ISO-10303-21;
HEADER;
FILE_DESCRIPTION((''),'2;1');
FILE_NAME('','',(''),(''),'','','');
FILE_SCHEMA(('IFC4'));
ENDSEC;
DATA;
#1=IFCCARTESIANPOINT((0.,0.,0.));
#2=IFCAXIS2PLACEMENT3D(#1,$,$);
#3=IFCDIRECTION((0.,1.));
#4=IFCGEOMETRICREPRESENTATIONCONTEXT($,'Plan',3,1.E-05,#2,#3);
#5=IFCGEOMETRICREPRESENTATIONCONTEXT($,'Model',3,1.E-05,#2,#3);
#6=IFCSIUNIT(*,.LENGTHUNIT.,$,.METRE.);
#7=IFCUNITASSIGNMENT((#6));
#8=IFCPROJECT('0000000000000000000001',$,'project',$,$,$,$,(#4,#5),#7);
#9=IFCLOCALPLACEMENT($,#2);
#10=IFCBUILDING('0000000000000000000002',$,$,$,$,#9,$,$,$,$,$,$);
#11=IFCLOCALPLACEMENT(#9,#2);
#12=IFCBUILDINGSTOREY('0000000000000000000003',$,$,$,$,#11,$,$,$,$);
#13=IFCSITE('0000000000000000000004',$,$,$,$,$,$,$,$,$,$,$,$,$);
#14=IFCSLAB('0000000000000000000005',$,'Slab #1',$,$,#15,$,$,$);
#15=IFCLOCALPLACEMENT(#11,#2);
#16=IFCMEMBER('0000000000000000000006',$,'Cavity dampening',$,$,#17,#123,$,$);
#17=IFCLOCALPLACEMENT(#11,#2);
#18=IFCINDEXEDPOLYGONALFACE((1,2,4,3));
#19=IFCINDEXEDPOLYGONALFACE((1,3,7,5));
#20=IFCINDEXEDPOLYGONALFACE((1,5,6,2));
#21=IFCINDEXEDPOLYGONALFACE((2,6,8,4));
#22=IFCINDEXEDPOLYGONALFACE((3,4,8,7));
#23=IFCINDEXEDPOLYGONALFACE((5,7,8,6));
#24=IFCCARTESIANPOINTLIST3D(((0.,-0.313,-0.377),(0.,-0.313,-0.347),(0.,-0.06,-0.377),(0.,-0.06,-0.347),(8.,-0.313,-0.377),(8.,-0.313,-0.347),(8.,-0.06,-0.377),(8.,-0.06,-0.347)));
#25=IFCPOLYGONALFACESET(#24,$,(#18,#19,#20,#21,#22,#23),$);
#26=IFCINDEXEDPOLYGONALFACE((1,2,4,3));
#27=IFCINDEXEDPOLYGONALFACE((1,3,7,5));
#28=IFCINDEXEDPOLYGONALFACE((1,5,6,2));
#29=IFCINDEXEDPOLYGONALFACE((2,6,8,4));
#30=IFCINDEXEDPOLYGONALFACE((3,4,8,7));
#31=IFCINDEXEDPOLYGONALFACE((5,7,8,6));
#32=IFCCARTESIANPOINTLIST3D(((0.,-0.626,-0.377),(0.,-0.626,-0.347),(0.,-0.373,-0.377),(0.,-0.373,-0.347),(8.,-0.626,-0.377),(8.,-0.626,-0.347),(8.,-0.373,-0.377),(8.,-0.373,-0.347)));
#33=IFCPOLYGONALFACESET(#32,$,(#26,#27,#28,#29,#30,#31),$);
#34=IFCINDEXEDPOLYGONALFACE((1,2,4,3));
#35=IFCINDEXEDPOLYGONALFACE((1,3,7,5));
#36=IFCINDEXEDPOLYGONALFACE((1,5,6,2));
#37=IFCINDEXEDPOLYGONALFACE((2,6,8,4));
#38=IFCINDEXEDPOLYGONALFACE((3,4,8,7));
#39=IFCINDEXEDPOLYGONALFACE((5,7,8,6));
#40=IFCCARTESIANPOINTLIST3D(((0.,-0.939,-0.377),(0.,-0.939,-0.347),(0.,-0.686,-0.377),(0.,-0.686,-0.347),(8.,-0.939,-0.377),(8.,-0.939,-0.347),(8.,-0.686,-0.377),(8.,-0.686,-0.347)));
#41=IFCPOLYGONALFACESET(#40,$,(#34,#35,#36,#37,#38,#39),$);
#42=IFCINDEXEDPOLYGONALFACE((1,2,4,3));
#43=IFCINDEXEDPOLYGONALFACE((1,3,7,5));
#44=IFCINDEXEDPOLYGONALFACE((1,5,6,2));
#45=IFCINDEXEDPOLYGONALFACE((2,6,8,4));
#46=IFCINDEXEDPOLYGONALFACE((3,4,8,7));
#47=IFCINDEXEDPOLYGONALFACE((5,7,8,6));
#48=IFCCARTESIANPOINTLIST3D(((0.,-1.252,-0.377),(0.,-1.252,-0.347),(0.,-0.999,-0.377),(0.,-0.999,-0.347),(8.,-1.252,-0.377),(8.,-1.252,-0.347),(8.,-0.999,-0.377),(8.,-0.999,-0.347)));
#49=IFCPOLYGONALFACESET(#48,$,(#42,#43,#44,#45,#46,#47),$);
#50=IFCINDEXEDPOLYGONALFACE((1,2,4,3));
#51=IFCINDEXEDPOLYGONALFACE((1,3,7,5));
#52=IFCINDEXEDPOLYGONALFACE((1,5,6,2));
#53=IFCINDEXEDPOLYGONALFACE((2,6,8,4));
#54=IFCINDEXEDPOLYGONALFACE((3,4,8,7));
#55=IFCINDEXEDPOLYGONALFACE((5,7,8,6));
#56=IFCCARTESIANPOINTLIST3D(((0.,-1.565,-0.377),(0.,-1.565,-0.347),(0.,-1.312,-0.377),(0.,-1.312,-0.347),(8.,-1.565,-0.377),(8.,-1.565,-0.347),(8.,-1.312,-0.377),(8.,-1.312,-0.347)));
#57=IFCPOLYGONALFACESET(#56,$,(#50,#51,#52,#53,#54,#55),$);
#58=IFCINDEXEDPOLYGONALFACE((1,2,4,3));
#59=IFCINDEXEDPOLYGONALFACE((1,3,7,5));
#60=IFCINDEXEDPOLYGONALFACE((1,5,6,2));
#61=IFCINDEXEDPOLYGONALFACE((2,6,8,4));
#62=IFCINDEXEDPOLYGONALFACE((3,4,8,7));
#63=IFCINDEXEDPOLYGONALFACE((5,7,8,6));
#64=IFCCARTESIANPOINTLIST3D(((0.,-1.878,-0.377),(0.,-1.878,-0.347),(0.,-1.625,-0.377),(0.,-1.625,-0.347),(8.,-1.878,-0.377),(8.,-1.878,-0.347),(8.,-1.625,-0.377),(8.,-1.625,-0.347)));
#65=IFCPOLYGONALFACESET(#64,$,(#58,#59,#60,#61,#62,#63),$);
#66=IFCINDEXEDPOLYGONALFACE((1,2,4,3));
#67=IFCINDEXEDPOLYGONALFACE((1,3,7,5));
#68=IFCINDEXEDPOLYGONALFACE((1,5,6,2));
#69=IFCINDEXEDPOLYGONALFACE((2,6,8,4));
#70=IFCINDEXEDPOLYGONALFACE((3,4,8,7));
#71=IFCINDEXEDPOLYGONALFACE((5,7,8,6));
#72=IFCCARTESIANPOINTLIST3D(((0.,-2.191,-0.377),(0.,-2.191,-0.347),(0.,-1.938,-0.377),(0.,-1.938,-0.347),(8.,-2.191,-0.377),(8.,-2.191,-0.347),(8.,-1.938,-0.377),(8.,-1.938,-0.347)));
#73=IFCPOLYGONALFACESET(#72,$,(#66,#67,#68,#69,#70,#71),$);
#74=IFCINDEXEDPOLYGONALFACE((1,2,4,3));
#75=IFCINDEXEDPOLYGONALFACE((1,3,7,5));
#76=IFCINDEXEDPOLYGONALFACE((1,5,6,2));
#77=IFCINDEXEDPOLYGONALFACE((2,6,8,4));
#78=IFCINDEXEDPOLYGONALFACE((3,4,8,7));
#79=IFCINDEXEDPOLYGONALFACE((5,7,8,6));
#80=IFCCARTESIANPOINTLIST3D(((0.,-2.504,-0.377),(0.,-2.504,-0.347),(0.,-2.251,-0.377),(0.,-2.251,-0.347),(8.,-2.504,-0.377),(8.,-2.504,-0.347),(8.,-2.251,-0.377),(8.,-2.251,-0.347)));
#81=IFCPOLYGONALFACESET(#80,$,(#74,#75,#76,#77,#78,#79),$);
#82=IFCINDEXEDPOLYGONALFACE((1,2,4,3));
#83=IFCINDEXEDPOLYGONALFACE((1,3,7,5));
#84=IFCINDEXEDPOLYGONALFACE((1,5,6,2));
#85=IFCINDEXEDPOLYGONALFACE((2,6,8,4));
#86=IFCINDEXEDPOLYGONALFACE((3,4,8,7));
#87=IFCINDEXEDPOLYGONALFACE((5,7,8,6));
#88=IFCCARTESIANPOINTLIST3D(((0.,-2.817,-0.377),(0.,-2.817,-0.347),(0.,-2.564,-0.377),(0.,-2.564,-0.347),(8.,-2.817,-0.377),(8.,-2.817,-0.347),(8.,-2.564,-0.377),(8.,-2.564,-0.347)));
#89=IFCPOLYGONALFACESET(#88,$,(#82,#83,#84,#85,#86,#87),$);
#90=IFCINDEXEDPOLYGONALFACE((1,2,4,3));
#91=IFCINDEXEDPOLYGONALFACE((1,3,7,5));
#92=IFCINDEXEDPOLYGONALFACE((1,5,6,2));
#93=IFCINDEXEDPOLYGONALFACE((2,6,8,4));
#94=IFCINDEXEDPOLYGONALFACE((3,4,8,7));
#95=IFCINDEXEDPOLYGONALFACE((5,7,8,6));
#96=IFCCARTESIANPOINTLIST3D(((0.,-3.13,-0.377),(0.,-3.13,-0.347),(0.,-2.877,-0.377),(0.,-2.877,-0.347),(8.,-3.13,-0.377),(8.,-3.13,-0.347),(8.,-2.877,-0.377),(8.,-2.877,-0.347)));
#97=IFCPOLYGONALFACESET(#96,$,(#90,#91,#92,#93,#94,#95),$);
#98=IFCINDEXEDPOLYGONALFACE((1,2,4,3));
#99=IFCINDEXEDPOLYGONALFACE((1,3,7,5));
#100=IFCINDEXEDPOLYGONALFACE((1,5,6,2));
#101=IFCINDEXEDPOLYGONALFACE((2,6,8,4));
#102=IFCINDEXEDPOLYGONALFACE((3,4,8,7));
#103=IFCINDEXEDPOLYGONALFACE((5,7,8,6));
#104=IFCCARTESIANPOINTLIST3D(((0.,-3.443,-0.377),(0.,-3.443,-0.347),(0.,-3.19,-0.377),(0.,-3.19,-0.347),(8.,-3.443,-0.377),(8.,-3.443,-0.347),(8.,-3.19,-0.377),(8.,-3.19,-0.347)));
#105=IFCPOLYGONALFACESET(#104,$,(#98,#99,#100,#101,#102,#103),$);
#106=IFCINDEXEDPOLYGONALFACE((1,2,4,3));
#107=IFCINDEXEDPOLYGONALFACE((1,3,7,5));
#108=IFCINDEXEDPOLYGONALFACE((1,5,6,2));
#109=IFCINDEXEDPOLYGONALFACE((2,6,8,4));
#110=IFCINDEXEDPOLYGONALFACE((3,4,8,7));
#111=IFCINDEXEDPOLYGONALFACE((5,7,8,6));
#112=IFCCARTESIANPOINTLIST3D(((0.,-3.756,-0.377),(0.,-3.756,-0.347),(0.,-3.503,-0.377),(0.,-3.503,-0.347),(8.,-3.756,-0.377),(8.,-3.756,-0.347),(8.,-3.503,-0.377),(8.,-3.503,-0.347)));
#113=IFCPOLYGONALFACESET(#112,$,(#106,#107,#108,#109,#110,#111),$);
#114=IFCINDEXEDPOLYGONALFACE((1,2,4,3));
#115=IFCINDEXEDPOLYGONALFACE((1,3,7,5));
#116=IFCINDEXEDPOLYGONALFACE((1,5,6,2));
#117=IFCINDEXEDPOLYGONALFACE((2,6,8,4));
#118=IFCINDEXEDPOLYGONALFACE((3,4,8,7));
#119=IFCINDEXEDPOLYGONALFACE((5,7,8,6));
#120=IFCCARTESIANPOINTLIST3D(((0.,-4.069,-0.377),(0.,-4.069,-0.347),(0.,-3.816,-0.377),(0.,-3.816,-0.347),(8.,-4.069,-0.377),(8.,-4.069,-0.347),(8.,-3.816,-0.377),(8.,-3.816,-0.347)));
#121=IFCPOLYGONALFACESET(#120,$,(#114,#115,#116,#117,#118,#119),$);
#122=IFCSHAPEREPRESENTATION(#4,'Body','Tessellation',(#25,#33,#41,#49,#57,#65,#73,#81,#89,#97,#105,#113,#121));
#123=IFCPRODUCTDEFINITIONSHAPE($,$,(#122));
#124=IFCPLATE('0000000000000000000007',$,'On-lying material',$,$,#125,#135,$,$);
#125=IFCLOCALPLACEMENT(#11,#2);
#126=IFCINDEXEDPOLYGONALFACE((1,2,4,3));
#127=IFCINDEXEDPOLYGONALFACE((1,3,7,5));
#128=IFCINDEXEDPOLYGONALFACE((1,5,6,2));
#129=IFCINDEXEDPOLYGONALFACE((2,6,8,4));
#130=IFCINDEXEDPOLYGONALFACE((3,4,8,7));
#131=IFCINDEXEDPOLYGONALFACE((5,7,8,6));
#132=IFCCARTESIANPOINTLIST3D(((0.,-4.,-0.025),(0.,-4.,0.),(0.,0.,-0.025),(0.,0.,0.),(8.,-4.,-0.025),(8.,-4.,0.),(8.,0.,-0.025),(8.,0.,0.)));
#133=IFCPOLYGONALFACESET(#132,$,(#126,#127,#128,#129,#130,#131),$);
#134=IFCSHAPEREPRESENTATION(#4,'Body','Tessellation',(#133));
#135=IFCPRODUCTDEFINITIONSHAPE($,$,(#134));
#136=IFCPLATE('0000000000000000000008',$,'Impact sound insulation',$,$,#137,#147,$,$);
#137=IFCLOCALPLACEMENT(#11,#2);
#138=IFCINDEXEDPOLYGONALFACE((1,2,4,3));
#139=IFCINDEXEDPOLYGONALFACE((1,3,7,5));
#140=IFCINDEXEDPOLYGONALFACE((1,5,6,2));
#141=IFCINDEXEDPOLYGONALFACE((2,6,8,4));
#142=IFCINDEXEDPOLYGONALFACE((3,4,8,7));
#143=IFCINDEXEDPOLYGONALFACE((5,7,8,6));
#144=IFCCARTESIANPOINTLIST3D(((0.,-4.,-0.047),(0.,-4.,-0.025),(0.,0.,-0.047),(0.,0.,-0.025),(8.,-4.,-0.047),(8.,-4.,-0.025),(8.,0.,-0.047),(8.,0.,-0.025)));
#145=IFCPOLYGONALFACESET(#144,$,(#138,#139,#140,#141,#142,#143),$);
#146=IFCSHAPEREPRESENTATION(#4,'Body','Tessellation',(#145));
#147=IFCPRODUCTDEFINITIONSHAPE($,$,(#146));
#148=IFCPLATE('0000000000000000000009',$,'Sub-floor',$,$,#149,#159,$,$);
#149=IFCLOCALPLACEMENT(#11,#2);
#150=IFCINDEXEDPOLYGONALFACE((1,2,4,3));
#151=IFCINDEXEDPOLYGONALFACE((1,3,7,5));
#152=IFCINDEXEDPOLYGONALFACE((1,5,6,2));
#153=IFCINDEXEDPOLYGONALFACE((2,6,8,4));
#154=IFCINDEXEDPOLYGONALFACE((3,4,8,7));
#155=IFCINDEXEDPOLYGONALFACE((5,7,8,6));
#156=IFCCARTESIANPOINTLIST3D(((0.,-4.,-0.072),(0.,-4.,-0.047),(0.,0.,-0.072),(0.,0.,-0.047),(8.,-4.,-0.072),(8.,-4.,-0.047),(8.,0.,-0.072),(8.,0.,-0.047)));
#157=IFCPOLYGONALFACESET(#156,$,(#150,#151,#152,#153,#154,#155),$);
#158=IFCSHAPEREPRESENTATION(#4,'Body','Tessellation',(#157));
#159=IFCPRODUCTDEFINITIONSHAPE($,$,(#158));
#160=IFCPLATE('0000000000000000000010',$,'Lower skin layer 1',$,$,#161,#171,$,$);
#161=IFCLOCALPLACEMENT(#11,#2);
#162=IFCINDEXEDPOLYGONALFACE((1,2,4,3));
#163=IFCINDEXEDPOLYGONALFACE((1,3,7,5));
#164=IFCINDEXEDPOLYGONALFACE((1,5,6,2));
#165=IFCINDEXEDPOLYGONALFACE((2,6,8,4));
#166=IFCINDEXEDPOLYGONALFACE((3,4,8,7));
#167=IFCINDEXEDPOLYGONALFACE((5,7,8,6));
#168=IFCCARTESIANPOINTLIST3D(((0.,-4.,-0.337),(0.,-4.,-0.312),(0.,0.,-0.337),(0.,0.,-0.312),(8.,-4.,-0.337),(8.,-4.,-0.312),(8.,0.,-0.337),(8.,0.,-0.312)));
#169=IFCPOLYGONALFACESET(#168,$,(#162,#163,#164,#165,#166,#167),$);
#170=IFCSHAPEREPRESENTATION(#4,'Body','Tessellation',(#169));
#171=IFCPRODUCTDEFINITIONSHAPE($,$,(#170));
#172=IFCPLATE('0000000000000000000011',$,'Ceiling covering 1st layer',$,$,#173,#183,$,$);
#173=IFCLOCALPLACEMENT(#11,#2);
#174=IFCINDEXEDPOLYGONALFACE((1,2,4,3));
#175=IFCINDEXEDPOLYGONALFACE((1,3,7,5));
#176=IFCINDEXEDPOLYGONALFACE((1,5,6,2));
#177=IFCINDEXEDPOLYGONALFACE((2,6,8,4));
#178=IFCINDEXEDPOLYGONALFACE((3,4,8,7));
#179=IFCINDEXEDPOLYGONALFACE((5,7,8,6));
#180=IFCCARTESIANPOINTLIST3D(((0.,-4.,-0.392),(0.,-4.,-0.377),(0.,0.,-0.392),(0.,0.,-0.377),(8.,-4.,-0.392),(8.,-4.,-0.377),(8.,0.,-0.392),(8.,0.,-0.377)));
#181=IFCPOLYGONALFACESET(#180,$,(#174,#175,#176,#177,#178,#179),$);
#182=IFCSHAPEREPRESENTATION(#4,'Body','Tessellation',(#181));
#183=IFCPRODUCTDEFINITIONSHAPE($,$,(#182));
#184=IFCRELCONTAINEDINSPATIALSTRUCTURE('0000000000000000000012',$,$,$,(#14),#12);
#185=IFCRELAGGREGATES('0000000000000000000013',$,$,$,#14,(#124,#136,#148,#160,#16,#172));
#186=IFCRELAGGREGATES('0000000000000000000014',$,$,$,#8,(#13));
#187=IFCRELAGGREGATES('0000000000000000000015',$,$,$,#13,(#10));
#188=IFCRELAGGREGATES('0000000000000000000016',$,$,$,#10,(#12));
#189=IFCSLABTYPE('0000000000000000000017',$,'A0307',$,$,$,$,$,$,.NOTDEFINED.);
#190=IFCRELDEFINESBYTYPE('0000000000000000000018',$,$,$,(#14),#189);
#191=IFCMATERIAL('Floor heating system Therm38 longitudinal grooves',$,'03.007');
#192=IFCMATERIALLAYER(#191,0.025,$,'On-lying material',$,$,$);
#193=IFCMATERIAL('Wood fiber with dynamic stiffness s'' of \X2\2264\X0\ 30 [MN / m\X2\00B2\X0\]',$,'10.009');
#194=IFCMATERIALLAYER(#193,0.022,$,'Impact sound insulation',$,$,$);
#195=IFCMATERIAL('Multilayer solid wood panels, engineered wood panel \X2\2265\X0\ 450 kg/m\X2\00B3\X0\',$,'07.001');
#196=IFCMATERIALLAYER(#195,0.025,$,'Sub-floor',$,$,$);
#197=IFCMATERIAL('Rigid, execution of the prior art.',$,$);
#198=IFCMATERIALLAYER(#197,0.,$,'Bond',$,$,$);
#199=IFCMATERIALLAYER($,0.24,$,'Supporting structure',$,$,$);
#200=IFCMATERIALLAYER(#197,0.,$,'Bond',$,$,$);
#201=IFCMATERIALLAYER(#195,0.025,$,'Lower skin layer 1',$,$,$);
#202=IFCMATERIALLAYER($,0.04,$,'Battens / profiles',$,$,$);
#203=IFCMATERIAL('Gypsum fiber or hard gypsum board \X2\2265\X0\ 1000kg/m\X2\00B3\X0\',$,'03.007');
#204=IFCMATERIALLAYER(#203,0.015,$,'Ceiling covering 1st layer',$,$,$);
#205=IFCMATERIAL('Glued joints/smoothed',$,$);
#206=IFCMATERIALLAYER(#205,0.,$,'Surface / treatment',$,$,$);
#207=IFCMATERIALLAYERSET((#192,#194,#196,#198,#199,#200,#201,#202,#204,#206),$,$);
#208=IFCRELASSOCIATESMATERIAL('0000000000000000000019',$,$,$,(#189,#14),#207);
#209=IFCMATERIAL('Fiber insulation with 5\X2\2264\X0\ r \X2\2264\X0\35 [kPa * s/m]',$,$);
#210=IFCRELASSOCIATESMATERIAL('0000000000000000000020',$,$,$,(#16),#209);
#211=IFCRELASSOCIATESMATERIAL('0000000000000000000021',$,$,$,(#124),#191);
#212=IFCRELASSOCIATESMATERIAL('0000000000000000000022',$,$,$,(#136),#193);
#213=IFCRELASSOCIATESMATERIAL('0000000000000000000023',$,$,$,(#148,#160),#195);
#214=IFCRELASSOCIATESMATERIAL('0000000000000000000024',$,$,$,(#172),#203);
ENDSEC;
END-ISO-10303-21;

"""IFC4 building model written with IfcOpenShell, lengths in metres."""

from ifc_helpers import new_model, si_unit, direction, frame, frame_2d, origin, origin_with_axes, place, context, project, spatial, rectangle, extrude, material, layer, layer_set, type_object, element, aggregate, save


model = new_model("IFC4")

# Units and contexts
plan_context = context("Plan", 3, precision=1e-05, world=origin(), true_north=direction((0.0, 1.0)))
model_context = context("Model", 3, precision=1e-05, world=origin(), true_north=direction((0.0, 1.0)))
ifc_project = project(units=[si_unit("LENGTHUNIT", "METRE")], contexts=[plan_context, model_context])

# Site, building, storey
site = spatial("IfcSite", under=ifc_project)
building_placement = place(None, origin())
building = spatial("IfcBuilding", under=site, at=building_placement)
storey_placement = place(building_placement, origin())
storey = spatial("IfcBuildingStorey", under=building, at=storey_placement)

# Slab, member, plates
ifc_material_1 = material(Name="Floor heating system Therm38 longitudinal grooves", Category="03.007")
ifc_layer_1 = layer(ifc_material_1, 0.025, Name="On-lying material")
ifc_material_2 = material(Name="Wood fiber with dynamic stiffness s' of ≤ 30 [MN / m²]", Category="10.009")
ifc_layer_2 = layer(ifc_material_2, 0.022, Name="Impact sound insulation")
ifc_material_3 = material(Name="Multilayer solid wood panels, engineered wood panel ≥ 450 kg/m³", Category="07.001")
ifc_layer_3 = layer(ifc_material_3, 0.025, Name="Sub-floor")
ifc_material_4 = material(Name="Rigid, execution of the prior art.")
ifc_layer_4 = layer(ifc_material_4, 0.0, Name="Bond")
ifc_layer_5 = layer(None, 0.24, Name="Supporting structure")
ifc_layer_6 = layer(ifc_material_4, 0.0, Name="Bond")
ifc_layer_7 = layer(ifc_material_3, 0.025, Name="Lower skin layer 1")
ifc_layer_8 = layer(None, 0.04, Name="Battens / profiles")
ifc_material_5 = material(Name="Gypsum fiber or hard gypsum board ≥ 1000kg/m³", Category="03.007")
ifc_layer_9 = layer(ifc_material_5, 0.015, Name="Ceiling covering 1st layer")
ifc_material_6 = material(Name="Glued joints/smoothed")
ifc_layer_10 = layer(ifc_material_6, 0.0, Name="Surface / treatment")
ifc_layer_set = layer_set([ifc_layer_1, ifc_layer_2, ifc_layer_3, ifc_layer_4, ifc_layer_5, ifc_layer_6, ifc_layer_7, ifc_layer_8, ifc_layer_9, ifc_layer_10])
slab_type = type_object("IfcSlabType", Name="A0307", PredefinedType="NOTDEFINED", material=ifc_layer_set)
slab_placement = place(None, frame((0.0, 0.0, 0.0), z_axis=(0.0, 0.0, -1.0), x_axis=(1.0, 0.0, 0.0)))
slab = element("IfcSlab", 1, at=slab_placement, inside=storey, type_object=slab_type, material=ifc_layer_set, Name="Slab #1")
ifc_material_7 = material(Name="Fiber insulation with 5≤ r ≤35 [kPa * s/m]")
member_1_placement = place(slab_placement, origin())
member_1 = element("IfcMember", 2, at=member_1_placement, material=ifc_material_7, Name="Cavity dampening", context=plan_context, shape_type="SweptSolid", body=[
    extrude(rectangle(XDim=0.253, YDim=0.03, at=frame_2d((0.1265, 0.015), x_axis=(1.0, 0.0))), frame((0.0, 0.06, 0.347), z_axis=(1.0, 0.0, 0.0), x_axis=(0.0, 1.0, 0.0)), (0.0, 0.0, 1.0), 8.0),
    extrude(rectangle(XDim=0.253, YDim=0.03, at=frame_2d((0.1265, 0.015), x_axis=(1.0, 0.0))), frame((0.0, 0.373, 0.347), z_axis=(1.0, 0.0, 0.0), x_axis=(0.0, 1.0, 0.0)), (0.0, 0.0, 1.0), 8.0),
    extrude(rectangle(XDim=0.253, YDim=0.03, at=frame_2d((0.1265, 0.015), x_axis=(1.0, 0.0))), frame((0.0, 0.686, 0.347), z_axis=(1.0, 0.0, 0.0), x_axis=(0.0, 1.0, 0.0)), (0.0, 0.0, 1.0), 8.0),
    extrude(rectangle(XDim=0.253, YDim=0.03, at=frame_2d((0.1265, 0.015), x_axis=(1.0, 0.0))), frame((0.0, 0.999, 0.347), z_axis=(1.0, 0.0, 0.0), x_axis=(0.0, 1.0, 0.0)), (0.0, 0.0, 1.0), 8.0),
    extrude(rectangle(XDim=0.253, YDim=0.03, at=frame_2d((0.1265, 0.015), x_axis=(1.0, 0.0))), frame((0.0, 1.312, 0.347), z_axis=(1.0, 0.0, 0.0), x_axis=(0.0, 1.0, 0.0)), (0.0, 0.0, 1.0), 8.0),
    extrude(rectangle(XDim=0.253, YDim=0.03, at=frame_2d((0.1265, 0.015), x_axis=(1.0, 0.0))), frame((0.0, 1.625, 0.347), z_axis=(1.0, 0.0, 0.0), x_axis=(0.0, 1.0, 0.0)), (0.0, 0.0, 1.0), 8.0),
    extrude(rectangle(XDim=0.253, YDim=0.03, at=frame_2d((0.1265, 0.015), x_axis=(1.0, 0.0))), frame((0.0, 1.938, 0.347), z_axis=(1.0, 0.0, 0.0), x_axis=(0.0, 1.0, 0.0)), (0.0, 0.0, 1.0), 8.0),
    extrude(rectangle(XDim=0.253, YDim=0.03, at=frame_2d((0.1265, 0.015), x_axis=(1.0, 0.0))), frame((0.0, 2.251, 0.347), z_axis=(1.0, 0.0, 0.0), x_axis=(0.0, 1.0, 0.0)), (0.0, 0.0, 1.0), 8.0),
    extrude(rectangle(XDim=0.253, YDim=0.03, at=frame_2d((0.1265, 0.015), x_axis=(1.0, 0.0))), frame((0.0, 2.564, 0.347), z_axis=(1.0, 0.0, 0.0), x_axis=(0.0, 1.0, 0.0)), (0.0, 0.0, 1.0), 8.0),
    extrude(rectangle(XDim=0.253, YDim=0.03, at=frame_2d((0.1265, 0.015), x_axis=(1.0, 0.0))), frame((0.0, 2.877, 0.347), z_axis=(1.0, 0.0, 0.0), x_axis=(0.0, 1.0, 0.0)), (0.0, 0.0, 1.0), 8.0),
    extrude(rectangle(XDim=0.253, YDim=0.03, at=frame_2d((0.1265, 0.015), x_axis=(1.0, 0.0))), frame((0.0, 3.19, 0.347), z_axis=(1.0, 0.0, 0.0), x_axis=(0.0, 1.0, 0.0)), (0.0, 0.0, 1.0), 8.0),
    extrude(rectangle(XDim=0.253, YDim=0.03, at=frame_2d((0.1265, 0.015), x_axis=(1.0, 0.0))), frame((0.0, 3.503, 0.347), z_axis=(1.0, 0.0, 0.0), x_axis=(0.0, 1.0, 0.0)), (0.0, 0.0, 1.0), 8.0),
    extrude(rectangle(XDim=0.253, YDim=0.03, at=frame_2d((0.1265, 0.015), x_axis=(1.0, 0.0))), frame((0.0, 3.816, 0.347), z_axis=(1.0, 0.0, 0.0), x_axis=(0.0, 1.0, 0.0)), (0.0, 0.0, 1.0), 8.0),
])
plate_1_placement = place(slab_placement, origin())
plate_1 = element("IfcPlate", 3, at=plate_1_placement, material=ifc_material_1, Name="On-lying material", context=plan_context, shape_type="SweptSolid", body=[
    extrude(rectangle(XDim=8.0, YDim=4.0, at=frame_2d((4.0, 2.0), x_axis=(1.0, 0.0))), origin_with_axes(), (0.0, 0.0, 1.0), 0.025),
])
plate_2_placement = place(slab_placement, origin())
plate_2 = element("IfcPlate", 4, at=plate_2_placement, material=ifc_material_2, Name="Impact sound insulation", context=plan_context, shape_type="SweptSolid", body=[
    extrude(rectangle(XDim=8.0, YDim=4.0, at=frame_2d((4.0, 2.0), x_axis=(1.0, 0.0))), frame((0.0, 0.0, 0.025), z_axis=(0.0, 0.0, 1.0), x_axis=(1.0, 0.0, 0.0)), (0.0, 0.0, 1.0), 0.022),
])
plate_3_placement = place(slab_placement, origin())
plate_3 = element("IfcPlate", 5, at=plate_3_placement, material=ifc_material_3, Name="Sub-floor", context=plan_context, shape_type="SweptSolid", body=[
    extrude(rectangle(XDim=8.0, YDim=4.0, at=frame_2d((4.0, 2.0), x_axis=(1.0, 0.0))), frame((0.0, 0.0, 0.047), z_axis=(0.0, 0.0, 1.0), x_axis=(1.0, 0.0, 0.0)), (0.0, 0.0, 1.0), 0.025),
])
plate_4_placement = place(slab_placement, origin())
plate_4 = element("IfcPlate", 6, at=plate_4_placement, material=ifc_material_3, Name="Lower skin layer 1", context=plan_context, shape_type="SweptSolid", body=[
    extrude(rectangle(XDim=8.0, YDim=4.0, at=frame_2d((4.0, 2.0), x_axis=(1.0, 0.0))), frame((0.0, 0.0, 0.312), z_axis=(0.0, 0.0, 1.0), x_axis=(1.0, 0.0, 0.0)), (0.0, 0.0, 1.0), 0.025),
])
plate_5_placement = place(slab_placement, origin())
plate_5 = element("IfcPlate", 7, at=plate_5_placement, material=ifc_material_5, Name="Ceiling covering 1st layer", context=plan_context, shape_type="SweptSolid", body=[
    extrude(rectangle(XDim=8.0, YDim=4.0, at=frame_2d((4.0, 2.0), x_axis=(1.0, 0.0))), frame((0.0, 0.0, 0.377), z_axis=(0.0, 0.0, 1.0), x_axis=(1.0, 0.0, 0.0)), (0.0, 0.0, 1.0), 0.015),
])
aggregate(slab, [plate_1, plate_2, plate_3, plate_4, member_1, plate_5])

save(model, "model.ifc")
